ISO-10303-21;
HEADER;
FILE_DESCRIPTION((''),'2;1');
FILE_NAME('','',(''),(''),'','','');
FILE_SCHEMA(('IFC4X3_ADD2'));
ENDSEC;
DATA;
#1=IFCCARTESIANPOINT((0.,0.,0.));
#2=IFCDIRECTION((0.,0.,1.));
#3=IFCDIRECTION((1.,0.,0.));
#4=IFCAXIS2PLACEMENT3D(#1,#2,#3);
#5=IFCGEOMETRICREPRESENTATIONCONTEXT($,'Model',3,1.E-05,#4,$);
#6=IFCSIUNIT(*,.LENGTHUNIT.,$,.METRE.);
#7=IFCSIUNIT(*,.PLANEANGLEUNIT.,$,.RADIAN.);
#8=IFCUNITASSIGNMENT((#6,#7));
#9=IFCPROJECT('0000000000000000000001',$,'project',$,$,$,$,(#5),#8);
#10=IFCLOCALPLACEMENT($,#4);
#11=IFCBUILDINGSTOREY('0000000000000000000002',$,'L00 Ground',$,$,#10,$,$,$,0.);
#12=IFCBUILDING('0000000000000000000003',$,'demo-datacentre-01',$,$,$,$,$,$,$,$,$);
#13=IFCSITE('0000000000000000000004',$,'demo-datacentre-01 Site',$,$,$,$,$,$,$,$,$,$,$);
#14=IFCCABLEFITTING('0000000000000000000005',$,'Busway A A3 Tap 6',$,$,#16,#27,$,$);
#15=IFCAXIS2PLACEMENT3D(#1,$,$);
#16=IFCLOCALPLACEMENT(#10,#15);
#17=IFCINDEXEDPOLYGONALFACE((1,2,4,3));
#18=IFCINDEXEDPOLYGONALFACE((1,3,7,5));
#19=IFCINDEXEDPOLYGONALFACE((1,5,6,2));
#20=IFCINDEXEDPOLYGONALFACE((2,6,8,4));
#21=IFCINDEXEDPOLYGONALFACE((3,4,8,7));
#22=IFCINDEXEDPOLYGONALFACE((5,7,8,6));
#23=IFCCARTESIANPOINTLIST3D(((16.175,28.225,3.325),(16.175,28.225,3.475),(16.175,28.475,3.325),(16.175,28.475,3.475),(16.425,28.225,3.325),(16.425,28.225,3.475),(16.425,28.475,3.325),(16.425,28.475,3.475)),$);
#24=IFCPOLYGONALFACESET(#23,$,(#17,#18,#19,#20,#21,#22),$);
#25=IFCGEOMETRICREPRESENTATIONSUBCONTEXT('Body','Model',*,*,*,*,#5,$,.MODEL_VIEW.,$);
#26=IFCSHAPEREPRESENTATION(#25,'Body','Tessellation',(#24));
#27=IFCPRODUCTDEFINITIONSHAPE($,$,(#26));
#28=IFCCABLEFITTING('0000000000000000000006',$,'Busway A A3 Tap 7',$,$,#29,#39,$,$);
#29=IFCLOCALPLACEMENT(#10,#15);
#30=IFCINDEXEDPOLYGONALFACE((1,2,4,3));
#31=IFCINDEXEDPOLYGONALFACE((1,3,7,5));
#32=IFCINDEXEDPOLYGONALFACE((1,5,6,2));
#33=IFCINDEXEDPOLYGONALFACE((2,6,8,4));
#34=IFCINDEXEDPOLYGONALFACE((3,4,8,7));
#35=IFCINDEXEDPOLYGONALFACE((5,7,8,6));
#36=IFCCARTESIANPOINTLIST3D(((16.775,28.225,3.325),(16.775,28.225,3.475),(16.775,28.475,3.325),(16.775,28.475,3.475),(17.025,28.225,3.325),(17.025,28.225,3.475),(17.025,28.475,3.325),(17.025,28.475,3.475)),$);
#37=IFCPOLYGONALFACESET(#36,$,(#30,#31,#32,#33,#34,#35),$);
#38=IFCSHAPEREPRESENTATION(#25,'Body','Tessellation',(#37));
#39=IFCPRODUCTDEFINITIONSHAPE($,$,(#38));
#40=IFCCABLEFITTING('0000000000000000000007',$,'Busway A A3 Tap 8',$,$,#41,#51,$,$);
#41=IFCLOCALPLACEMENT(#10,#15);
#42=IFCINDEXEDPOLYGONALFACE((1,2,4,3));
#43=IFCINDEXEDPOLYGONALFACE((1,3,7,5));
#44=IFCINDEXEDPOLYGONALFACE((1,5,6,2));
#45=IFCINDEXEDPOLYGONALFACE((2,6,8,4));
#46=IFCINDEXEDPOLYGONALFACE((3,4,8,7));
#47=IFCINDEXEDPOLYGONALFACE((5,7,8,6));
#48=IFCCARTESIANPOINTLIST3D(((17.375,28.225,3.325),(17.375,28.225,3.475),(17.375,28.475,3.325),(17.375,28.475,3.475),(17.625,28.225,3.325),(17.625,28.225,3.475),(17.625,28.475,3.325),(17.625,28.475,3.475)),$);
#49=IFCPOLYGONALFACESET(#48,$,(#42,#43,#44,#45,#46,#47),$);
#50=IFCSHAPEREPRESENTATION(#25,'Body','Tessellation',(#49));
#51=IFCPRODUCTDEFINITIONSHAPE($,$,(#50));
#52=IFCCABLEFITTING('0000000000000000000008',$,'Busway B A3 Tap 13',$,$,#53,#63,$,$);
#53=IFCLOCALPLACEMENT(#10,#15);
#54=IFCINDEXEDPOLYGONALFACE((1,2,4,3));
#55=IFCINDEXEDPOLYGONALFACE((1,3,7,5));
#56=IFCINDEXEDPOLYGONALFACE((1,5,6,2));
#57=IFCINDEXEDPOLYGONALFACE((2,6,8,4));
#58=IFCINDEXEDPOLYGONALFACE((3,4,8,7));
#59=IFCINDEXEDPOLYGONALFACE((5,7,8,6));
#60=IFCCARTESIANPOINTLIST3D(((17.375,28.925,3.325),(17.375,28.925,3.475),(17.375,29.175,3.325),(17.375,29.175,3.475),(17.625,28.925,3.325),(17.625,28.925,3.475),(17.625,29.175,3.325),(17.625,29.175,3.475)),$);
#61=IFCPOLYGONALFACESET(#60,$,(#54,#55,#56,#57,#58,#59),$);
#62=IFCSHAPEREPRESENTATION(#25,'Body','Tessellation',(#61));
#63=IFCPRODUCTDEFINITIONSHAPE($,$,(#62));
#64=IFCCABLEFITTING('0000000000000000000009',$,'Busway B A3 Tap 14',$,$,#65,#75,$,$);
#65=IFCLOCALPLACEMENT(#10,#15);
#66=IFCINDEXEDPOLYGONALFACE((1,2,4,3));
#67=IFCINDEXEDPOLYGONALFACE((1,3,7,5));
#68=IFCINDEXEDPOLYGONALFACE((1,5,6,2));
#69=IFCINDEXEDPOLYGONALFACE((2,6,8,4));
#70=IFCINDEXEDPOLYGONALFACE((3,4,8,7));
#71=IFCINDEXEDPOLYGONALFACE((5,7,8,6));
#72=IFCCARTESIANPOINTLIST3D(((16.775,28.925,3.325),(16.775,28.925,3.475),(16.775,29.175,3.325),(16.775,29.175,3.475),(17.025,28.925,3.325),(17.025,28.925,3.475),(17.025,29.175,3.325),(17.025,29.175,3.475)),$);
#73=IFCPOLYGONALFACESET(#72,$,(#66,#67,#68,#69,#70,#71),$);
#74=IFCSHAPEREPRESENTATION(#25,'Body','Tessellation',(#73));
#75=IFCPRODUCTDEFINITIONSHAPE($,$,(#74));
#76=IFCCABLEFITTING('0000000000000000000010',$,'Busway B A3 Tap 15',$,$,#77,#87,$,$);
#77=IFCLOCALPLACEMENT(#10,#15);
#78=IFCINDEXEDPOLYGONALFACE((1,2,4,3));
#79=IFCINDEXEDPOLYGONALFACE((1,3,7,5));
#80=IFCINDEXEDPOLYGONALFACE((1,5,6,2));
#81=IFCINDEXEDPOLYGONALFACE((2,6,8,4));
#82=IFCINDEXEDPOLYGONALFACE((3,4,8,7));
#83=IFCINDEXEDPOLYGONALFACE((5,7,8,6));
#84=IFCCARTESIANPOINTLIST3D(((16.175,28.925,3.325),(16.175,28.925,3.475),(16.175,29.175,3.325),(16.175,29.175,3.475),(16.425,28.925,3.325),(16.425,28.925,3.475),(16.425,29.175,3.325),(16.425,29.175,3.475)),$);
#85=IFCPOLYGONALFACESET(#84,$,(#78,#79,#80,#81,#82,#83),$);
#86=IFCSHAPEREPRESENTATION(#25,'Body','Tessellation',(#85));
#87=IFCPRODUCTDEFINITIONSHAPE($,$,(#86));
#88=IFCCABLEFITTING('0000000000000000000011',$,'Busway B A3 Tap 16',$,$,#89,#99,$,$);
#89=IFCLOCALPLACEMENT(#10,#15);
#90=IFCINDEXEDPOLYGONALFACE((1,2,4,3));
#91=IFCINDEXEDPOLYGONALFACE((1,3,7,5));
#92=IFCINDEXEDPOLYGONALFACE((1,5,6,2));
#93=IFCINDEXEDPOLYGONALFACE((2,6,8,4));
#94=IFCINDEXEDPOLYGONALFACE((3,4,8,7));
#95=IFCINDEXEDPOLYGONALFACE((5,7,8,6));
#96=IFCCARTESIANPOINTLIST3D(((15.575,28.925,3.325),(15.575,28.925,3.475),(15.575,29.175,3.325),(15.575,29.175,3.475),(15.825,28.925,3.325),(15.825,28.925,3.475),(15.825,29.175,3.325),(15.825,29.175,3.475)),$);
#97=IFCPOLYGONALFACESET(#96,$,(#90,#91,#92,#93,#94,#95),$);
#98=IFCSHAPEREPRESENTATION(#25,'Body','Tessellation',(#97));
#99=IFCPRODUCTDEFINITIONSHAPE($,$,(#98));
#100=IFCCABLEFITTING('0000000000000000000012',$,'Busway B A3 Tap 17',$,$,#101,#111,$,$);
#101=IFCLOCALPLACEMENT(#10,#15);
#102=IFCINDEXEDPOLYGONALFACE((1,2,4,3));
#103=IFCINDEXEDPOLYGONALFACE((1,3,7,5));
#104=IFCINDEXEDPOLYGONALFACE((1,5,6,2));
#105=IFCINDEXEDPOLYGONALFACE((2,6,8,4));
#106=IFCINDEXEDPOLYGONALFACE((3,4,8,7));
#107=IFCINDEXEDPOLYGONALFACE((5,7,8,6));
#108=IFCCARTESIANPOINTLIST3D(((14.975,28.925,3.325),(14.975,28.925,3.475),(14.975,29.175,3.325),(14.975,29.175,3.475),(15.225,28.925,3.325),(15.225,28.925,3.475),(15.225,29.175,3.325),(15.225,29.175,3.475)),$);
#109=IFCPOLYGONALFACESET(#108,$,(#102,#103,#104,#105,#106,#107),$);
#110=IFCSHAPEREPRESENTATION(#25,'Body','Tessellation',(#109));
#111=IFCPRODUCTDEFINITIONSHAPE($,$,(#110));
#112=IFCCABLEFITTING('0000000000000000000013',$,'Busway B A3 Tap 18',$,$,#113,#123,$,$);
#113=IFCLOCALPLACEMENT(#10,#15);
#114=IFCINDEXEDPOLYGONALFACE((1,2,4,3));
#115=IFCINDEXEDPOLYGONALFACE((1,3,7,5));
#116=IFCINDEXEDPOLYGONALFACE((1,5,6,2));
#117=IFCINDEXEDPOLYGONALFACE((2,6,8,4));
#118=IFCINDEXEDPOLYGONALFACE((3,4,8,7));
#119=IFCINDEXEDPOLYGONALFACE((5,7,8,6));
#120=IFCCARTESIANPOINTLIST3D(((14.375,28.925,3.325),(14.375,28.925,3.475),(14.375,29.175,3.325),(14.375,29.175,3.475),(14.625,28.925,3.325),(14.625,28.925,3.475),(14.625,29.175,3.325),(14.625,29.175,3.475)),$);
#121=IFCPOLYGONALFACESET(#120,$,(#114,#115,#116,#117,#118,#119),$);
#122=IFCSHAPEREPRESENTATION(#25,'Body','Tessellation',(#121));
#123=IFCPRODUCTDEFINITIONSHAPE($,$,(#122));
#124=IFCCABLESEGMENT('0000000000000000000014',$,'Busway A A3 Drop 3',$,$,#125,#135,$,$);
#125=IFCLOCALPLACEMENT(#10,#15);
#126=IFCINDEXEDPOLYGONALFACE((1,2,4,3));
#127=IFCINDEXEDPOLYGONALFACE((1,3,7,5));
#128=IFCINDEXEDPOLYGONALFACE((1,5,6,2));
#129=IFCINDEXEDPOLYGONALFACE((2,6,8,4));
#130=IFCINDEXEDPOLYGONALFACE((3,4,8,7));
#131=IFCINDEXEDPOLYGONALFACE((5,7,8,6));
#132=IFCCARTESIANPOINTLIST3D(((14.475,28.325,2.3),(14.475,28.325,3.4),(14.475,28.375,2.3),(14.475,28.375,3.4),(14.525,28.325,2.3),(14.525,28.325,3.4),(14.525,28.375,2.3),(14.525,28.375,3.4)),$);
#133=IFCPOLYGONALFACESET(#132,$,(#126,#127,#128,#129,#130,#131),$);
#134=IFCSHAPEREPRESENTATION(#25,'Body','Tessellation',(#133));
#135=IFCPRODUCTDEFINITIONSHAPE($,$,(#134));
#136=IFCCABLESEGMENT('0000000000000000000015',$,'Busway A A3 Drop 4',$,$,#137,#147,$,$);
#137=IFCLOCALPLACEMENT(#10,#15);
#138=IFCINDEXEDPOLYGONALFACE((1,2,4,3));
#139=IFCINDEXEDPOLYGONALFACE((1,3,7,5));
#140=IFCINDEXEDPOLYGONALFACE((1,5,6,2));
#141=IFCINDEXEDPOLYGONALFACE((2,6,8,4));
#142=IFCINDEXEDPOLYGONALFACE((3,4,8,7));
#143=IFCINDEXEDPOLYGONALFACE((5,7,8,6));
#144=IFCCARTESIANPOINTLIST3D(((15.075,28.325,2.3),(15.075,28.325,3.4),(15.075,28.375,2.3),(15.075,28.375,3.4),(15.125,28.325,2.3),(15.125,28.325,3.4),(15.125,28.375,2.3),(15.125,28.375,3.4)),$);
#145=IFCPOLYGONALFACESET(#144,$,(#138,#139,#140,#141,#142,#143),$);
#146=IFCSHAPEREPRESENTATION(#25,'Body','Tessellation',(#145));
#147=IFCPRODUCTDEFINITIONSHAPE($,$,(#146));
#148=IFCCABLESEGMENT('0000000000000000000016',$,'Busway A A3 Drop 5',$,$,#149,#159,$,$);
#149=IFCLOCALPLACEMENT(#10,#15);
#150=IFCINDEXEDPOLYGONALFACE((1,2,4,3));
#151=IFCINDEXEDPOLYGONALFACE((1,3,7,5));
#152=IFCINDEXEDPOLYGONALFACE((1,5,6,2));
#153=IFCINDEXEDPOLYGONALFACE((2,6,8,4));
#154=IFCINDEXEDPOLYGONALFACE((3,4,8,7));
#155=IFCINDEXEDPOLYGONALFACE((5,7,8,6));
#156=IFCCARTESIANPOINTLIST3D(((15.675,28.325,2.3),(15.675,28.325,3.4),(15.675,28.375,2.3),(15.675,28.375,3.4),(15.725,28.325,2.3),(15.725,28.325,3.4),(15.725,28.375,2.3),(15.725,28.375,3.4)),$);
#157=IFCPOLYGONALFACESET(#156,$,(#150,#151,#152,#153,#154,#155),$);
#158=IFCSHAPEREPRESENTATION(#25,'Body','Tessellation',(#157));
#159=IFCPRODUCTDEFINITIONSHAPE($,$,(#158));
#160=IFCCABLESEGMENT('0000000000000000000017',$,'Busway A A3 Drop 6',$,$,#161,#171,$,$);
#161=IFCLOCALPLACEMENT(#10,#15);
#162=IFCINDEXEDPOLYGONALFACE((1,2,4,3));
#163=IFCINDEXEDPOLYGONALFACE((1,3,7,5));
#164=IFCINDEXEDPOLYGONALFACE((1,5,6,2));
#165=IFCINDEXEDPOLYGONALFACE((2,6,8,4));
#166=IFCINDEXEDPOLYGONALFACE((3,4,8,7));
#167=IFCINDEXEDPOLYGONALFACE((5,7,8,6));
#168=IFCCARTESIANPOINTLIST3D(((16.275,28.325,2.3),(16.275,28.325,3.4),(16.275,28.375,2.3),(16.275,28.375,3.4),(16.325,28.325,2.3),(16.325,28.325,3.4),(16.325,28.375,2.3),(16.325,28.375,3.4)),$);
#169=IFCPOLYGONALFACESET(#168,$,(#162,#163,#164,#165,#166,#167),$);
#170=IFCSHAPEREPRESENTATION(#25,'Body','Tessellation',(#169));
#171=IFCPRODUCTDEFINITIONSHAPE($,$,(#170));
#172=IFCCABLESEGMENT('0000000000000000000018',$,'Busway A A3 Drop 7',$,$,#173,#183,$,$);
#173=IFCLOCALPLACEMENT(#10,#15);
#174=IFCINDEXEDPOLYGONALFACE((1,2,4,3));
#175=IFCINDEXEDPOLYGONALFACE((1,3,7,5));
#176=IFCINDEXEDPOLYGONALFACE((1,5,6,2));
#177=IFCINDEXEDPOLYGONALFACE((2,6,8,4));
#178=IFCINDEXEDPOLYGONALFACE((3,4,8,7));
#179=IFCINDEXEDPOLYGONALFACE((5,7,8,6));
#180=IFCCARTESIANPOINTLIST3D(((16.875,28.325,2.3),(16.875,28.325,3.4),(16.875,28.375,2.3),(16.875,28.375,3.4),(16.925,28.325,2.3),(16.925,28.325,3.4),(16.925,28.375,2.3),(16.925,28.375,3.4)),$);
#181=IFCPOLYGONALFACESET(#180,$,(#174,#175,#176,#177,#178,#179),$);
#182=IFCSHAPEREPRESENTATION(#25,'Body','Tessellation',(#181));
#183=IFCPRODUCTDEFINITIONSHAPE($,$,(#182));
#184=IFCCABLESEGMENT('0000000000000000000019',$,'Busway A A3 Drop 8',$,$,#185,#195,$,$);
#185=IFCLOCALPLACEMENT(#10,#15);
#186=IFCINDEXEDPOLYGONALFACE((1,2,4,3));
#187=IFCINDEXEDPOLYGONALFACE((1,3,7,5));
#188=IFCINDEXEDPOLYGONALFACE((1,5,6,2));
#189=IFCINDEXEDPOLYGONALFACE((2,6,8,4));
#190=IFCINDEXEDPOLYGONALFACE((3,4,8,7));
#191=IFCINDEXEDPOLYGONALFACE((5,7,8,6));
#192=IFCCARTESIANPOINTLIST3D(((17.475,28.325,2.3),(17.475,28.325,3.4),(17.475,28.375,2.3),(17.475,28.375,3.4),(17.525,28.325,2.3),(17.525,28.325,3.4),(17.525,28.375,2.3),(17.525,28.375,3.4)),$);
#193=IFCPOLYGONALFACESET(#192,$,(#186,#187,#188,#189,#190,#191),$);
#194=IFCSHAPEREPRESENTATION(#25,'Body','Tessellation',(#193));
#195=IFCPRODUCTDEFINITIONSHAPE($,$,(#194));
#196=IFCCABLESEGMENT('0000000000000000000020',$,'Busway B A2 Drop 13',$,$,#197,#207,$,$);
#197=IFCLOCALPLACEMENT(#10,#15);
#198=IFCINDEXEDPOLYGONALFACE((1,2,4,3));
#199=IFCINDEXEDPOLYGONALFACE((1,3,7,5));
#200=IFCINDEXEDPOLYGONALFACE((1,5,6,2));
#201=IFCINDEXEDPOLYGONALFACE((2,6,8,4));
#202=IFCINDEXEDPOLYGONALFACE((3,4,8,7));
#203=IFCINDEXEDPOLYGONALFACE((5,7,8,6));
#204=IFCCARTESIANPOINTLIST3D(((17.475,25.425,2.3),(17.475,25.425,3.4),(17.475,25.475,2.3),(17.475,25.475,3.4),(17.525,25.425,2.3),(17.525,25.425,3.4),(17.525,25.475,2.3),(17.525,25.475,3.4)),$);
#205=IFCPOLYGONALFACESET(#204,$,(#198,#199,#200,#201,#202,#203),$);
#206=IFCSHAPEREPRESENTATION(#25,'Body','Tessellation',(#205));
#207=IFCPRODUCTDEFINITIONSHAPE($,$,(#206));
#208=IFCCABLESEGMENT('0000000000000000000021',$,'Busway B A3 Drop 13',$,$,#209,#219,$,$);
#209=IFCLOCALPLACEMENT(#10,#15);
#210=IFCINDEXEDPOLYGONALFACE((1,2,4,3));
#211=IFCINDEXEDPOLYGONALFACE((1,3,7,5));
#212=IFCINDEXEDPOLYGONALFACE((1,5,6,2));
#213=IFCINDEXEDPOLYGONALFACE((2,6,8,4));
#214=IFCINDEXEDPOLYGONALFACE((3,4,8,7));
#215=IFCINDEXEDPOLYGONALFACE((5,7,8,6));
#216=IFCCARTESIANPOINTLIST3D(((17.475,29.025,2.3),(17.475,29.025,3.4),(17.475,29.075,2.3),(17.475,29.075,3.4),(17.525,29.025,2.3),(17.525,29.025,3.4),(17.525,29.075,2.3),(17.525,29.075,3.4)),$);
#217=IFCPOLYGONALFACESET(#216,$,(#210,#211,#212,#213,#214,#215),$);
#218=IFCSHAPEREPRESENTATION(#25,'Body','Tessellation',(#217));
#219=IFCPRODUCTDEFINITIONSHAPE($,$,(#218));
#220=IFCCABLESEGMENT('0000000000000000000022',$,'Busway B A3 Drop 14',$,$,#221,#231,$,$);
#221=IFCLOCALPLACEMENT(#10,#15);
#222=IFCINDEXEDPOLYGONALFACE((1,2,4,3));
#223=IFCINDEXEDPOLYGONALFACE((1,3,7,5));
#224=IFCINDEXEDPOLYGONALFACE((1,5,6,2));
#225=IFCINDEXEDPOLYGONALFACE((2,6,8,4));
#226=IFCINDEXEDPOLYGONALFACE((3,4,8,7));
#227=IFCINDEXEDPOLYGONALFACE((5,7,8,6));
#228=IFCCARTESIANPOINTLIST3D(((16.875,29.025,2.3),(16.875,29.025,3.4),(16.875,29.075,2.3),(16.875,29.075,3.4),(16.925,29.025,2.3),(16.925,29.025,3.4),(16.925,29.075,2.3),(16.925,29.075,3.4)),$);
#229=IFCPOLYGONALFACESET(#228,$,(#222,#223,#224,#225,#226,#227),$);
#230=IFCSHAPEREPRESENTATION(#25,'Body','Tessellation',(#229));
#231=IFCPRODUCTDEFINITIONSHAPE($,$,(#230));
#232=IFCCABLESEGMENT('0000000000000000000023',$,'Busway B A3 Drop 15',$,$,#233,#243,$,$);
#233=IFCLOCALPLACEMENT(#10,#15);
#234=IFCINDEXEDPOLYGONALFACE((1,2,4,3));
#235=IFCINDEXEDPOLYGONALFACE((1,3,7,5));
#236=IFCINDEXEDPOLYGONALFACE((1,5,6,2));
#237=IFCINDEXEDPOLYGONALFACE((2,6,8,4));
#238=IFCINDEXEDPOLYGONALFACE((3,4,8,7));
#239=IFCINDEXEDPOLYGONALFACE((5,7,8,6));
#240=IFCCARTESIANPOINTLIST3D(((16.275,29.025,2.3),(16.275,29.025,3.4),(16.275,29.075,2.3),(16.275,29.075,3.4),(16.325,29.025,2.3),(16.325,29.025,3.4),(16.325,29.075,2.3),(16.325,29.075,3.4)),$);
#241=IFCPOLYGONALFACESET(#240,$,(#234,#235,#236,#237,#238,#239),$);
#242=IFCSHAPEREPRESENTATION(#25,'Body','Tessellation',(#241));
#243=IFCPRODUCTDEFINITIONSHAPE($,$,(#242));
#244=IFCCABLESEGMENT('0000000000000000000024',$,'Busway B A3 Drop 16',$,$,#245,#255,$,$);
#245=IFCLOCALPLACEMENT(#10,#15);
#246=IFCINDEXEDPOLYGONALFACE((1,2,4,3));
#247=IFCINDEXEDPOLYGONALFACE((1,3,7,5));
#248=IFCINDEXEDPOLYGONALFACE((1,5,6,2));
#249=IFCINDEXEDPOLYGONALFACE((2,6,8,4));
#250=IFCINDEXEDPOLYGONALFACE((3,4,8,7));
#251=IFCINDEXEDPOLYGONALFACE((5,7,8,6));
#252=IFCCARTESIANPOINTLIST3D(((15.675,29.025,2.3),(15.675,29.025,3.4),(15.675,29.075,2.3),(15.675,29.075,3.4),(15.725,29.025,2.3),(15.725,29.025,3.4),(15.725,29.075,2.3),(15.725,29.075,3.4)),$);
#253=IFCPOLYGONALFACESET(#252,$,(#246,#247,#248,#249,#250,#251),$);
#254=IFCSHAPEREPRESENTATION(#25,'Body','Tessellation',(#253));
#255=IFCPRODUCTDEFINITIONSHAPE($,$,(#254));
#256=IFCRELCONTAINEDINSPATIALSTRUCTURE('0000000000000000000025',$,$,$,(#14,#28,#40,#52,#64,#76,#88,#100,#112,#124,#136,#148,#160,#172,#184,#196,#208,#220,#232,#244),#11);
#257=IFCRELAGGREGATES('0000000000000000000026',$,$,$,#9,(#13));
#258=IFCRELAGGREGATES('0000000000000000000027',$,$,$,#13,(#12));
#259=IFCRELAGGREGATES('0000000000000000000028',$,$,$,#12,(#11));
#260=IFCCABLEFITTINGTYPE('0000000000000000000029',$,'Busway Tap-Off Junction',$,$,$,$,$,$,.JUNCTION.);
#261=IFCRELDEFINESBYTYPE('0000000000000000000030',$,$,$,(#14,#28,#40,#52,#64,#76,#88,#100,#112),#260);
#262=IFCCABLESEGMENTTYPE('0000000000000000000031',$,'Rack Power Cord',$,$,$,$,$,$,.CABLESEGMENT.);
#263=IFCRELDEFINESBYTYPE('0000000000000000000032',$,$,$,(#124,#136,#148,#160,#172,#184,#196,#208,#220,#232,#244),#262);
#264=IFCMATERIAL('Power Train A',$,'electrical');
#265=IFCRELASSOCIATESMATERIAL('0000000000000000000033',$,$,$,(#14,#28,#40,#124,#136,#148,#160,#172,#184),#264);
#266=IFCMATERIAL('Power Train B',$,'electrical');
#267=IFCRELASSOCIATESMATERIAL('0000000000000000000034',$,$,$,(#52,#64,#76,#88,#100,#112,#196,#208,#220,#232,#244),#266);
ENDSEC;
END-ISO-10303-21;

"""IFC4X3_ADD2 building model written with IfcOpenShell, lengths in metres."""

from ifc_helpers import new_model, si_unit, frame, origin_with_axes, place, context, subcontext, project, spatial, rectangle, extrude, material, type_object, element, save


model = new_model("IFC4X3_ADD2")

# Units and contexts
model_context = context("Model", 3, precision=1e-05, world=origin_with_axes())
body_context = subcontext(model_context, "Body", "Model", "MODEL_VIEW")
ifc_project = project(units=[si_unit("LENGTHUNIT", "METRE"), si_unit("PLANEANGLEUNIT", "RADIAN")], contexts=[model_context])

# Site, building, storey
site = spatial("IfcSite", under=ifc_project, Name="demo-datacentre-01 Site")
building = spatial("IfcBuilding", under=site, Name="demo-datacentre-01")
storey_placement = place(None, origin_with_axes())
storey = spatial("IfcBuildingStorey", under=building, at=storey_placement, Name="L00 Ground", Elevation=0.0)

# Shared definitions
ifc_material_1 = material(Name="Power Train A", Category="electrical")
ifc_material_2 = material(Name="Power Train B", Category="electrical")

# Cable fittings
cable_fitting_type = type_object("IfcCableFittingType", Name="Busway Tap-Off Junction", PredefinedType="JUNCTION")
for number, where, z_axis, x_axis, name in (
    (1, (16.3, 28.35, 3.325), (0.0, 0.0, 1.0), (1.0, 0.0, 0.0), "Busway A A3 Tap 6"),
    (2, (16.9, 28.35, 3.325), (0.0, 0.0, 1.0), (1.0, 0.0, 0.0), "Busway A A3 Tap 7"),
    (3, (17.5, 28.35, 3.325), (0.0, 0.0, 1.0), (1.0, 0.0, 0.0), "Busway A A3 Tap 8"),
):
    element("IfcCableFitting", number, at=place(storey_placement, frame(where, z_axis=z_axis, x_axis=x_axis)), inside=storey, type_object=cable_fitting_type, material=ifc_material_1, Name=name, context=body_context, shape_type="SweptSolid", body=[
        extrude(rectangle(XDim=0.25, YDim=0.25), origin_with_axes(), (0.0, 0.0, 1.0), 0.15),
    ])
for number, where, z_axis, x_axis, name in (
    (4, (17.5, 29.05, 3.325), (0.0, 0.0, 1.0), (1.0, 0.0, 0.0), "Busway B A3 Tap 13"),
    (5, (16.9, 29.05, 3.325), (0.0, 0.0, 1.0), (1.0, 0.0, 0.0), "Busway B A3 Tap 14"),
    (6, (16.3, 29.05, 3.325), (0.0, 0.0, 1.0), (1.0, 0.0, 0.0), "Busway B A3 Tap 15"),
    (7, (15.7, 29.05, 3.325), (0.0, 0.0, 1.0), (1.0, 0.0, 0.0), "Busway B A3 Tap 16"),
    (8, (15.1, 29.05, 3.325), (0.0, 0.0, 1.0), (1.0, 0.0, 0.0), "Busway B A3 Tap 17"),
    (9, (14.5, 29.05, 3.325), (0.0, 0.0, 1.0), (1.0, 0.0, 0.0), "Busway B A3 Tap 18"),
):
    element("IfcCableFitting", number, at=place(storey_placement, frame(where, z_axis=z_axis, x_axis=x_axis)), inside=storey, type_object=cable_fitting_type, material=ifc_material_2, Name=name, context=body_context, shape_type="SweptSolid", body=[
        extrude(rectangle(XDim=0.25, YDim=0.25), origin_with_axes(), (0.0, 0.0, 1.0), 0.15),
    ])

# Cable segments
cable_segment_type_1 = type_object("IfcCableSegmentType", Name="Rack Power Cord", PredefinedType="CABLESEGMENT")
for number, where, z_axis, x_axis, name in (
    (10, (14.5, 28.35, 3.4), (0.0, 0.0, -1.0), (1.0, 0.0, 0.0), "Busway A A3 Drop 3"),
    (11, (15.1, 28.35, 3.4), (0.0, 0.0, -1.0), (1.0, 0.0, 0.0), "Busway A A3 Drop 4"),
    (12, (15.7, 28.35, 3.4), (0.0, 0.0, -1.0), (1.0, 0.0, 0.0), "Busway A A3 Drop 5"),
    (13, (16.3, 28.35, 3.4), (0.0, 0.0, -1.0), (1.0, 0.0, 0.0), "Busway A A3 Drop 6"),
    (14, (16.9, 28.35, 3.4), (0.0, 0.0, -1.0), (1.0, 0.0, 0.0), "Busway A A3 Drop 7"),
    (15, (17.5, 28.35, 3.4), (0.0, 0.0, -1.0), (1.0, 0.0, 0.0), "Busway A A3 Drop 8"),
):
    element("IfcCableSegment", number, at=place(storey_placement, frame(where, z_axis=z_axis, x_axis=x_axis)), inside=storey, type_object=cable_segment_type_1, material=ifc_material_1, Name=name, context=body_context, shape_type="SweptSolid", body=[
        extrude(rectangle(XDim=0.05, YDim=0.05), origin_with_axes(), (0.0, 0.0, 1.0), 1.1),
    ])
for number, where, z_axis, x_axis, name in (
    (16, (17.5, 25.45, 3.4), (0.0, 0.0, -1.0), (1.0, 0.0, 0.0), "Busway B A2 Drop 13"),
    (17, (17.5, 29.05, 3.4), (0.0, 0.0, -1.0), (1.0, 0.0, 0.0), "Busway B A3 Drop 13"),
    (18, (16.9, 29.05, 3.4), (0.0, 0.0, -1.0), (1.0, 0.0, 0.0), "Busway B A3 Drop 14"),
    (19, (16.3, 29.05, 3.4), (0.0, 0.0, -1.0), (1.0, 0.0, 0.0), "Busway B A3 Drop 15"),
    (20, (15.7, 29.05, 3.4), (0.0, 0.0, -1.0), (1.0, 0.0, 0.0), "Busway B A3 Drop 16"),
):
    element("IfcCableSegment", number, at=place(storey_placement, frame(where, z_axis=z_axis, x_axis=x_axis)), inside=storey, type_object=cable_segment_type_1, material=ifc_material_2, Name=name, context=body_context, shape_type="SweptSolid", body=[
        extrude(rectangle(XDim=0.05, YDim=0.05), origin_with_axes(), (0.0, 0.0, 1.0), 1.1),
    ])

save(model, "model.ifc")
